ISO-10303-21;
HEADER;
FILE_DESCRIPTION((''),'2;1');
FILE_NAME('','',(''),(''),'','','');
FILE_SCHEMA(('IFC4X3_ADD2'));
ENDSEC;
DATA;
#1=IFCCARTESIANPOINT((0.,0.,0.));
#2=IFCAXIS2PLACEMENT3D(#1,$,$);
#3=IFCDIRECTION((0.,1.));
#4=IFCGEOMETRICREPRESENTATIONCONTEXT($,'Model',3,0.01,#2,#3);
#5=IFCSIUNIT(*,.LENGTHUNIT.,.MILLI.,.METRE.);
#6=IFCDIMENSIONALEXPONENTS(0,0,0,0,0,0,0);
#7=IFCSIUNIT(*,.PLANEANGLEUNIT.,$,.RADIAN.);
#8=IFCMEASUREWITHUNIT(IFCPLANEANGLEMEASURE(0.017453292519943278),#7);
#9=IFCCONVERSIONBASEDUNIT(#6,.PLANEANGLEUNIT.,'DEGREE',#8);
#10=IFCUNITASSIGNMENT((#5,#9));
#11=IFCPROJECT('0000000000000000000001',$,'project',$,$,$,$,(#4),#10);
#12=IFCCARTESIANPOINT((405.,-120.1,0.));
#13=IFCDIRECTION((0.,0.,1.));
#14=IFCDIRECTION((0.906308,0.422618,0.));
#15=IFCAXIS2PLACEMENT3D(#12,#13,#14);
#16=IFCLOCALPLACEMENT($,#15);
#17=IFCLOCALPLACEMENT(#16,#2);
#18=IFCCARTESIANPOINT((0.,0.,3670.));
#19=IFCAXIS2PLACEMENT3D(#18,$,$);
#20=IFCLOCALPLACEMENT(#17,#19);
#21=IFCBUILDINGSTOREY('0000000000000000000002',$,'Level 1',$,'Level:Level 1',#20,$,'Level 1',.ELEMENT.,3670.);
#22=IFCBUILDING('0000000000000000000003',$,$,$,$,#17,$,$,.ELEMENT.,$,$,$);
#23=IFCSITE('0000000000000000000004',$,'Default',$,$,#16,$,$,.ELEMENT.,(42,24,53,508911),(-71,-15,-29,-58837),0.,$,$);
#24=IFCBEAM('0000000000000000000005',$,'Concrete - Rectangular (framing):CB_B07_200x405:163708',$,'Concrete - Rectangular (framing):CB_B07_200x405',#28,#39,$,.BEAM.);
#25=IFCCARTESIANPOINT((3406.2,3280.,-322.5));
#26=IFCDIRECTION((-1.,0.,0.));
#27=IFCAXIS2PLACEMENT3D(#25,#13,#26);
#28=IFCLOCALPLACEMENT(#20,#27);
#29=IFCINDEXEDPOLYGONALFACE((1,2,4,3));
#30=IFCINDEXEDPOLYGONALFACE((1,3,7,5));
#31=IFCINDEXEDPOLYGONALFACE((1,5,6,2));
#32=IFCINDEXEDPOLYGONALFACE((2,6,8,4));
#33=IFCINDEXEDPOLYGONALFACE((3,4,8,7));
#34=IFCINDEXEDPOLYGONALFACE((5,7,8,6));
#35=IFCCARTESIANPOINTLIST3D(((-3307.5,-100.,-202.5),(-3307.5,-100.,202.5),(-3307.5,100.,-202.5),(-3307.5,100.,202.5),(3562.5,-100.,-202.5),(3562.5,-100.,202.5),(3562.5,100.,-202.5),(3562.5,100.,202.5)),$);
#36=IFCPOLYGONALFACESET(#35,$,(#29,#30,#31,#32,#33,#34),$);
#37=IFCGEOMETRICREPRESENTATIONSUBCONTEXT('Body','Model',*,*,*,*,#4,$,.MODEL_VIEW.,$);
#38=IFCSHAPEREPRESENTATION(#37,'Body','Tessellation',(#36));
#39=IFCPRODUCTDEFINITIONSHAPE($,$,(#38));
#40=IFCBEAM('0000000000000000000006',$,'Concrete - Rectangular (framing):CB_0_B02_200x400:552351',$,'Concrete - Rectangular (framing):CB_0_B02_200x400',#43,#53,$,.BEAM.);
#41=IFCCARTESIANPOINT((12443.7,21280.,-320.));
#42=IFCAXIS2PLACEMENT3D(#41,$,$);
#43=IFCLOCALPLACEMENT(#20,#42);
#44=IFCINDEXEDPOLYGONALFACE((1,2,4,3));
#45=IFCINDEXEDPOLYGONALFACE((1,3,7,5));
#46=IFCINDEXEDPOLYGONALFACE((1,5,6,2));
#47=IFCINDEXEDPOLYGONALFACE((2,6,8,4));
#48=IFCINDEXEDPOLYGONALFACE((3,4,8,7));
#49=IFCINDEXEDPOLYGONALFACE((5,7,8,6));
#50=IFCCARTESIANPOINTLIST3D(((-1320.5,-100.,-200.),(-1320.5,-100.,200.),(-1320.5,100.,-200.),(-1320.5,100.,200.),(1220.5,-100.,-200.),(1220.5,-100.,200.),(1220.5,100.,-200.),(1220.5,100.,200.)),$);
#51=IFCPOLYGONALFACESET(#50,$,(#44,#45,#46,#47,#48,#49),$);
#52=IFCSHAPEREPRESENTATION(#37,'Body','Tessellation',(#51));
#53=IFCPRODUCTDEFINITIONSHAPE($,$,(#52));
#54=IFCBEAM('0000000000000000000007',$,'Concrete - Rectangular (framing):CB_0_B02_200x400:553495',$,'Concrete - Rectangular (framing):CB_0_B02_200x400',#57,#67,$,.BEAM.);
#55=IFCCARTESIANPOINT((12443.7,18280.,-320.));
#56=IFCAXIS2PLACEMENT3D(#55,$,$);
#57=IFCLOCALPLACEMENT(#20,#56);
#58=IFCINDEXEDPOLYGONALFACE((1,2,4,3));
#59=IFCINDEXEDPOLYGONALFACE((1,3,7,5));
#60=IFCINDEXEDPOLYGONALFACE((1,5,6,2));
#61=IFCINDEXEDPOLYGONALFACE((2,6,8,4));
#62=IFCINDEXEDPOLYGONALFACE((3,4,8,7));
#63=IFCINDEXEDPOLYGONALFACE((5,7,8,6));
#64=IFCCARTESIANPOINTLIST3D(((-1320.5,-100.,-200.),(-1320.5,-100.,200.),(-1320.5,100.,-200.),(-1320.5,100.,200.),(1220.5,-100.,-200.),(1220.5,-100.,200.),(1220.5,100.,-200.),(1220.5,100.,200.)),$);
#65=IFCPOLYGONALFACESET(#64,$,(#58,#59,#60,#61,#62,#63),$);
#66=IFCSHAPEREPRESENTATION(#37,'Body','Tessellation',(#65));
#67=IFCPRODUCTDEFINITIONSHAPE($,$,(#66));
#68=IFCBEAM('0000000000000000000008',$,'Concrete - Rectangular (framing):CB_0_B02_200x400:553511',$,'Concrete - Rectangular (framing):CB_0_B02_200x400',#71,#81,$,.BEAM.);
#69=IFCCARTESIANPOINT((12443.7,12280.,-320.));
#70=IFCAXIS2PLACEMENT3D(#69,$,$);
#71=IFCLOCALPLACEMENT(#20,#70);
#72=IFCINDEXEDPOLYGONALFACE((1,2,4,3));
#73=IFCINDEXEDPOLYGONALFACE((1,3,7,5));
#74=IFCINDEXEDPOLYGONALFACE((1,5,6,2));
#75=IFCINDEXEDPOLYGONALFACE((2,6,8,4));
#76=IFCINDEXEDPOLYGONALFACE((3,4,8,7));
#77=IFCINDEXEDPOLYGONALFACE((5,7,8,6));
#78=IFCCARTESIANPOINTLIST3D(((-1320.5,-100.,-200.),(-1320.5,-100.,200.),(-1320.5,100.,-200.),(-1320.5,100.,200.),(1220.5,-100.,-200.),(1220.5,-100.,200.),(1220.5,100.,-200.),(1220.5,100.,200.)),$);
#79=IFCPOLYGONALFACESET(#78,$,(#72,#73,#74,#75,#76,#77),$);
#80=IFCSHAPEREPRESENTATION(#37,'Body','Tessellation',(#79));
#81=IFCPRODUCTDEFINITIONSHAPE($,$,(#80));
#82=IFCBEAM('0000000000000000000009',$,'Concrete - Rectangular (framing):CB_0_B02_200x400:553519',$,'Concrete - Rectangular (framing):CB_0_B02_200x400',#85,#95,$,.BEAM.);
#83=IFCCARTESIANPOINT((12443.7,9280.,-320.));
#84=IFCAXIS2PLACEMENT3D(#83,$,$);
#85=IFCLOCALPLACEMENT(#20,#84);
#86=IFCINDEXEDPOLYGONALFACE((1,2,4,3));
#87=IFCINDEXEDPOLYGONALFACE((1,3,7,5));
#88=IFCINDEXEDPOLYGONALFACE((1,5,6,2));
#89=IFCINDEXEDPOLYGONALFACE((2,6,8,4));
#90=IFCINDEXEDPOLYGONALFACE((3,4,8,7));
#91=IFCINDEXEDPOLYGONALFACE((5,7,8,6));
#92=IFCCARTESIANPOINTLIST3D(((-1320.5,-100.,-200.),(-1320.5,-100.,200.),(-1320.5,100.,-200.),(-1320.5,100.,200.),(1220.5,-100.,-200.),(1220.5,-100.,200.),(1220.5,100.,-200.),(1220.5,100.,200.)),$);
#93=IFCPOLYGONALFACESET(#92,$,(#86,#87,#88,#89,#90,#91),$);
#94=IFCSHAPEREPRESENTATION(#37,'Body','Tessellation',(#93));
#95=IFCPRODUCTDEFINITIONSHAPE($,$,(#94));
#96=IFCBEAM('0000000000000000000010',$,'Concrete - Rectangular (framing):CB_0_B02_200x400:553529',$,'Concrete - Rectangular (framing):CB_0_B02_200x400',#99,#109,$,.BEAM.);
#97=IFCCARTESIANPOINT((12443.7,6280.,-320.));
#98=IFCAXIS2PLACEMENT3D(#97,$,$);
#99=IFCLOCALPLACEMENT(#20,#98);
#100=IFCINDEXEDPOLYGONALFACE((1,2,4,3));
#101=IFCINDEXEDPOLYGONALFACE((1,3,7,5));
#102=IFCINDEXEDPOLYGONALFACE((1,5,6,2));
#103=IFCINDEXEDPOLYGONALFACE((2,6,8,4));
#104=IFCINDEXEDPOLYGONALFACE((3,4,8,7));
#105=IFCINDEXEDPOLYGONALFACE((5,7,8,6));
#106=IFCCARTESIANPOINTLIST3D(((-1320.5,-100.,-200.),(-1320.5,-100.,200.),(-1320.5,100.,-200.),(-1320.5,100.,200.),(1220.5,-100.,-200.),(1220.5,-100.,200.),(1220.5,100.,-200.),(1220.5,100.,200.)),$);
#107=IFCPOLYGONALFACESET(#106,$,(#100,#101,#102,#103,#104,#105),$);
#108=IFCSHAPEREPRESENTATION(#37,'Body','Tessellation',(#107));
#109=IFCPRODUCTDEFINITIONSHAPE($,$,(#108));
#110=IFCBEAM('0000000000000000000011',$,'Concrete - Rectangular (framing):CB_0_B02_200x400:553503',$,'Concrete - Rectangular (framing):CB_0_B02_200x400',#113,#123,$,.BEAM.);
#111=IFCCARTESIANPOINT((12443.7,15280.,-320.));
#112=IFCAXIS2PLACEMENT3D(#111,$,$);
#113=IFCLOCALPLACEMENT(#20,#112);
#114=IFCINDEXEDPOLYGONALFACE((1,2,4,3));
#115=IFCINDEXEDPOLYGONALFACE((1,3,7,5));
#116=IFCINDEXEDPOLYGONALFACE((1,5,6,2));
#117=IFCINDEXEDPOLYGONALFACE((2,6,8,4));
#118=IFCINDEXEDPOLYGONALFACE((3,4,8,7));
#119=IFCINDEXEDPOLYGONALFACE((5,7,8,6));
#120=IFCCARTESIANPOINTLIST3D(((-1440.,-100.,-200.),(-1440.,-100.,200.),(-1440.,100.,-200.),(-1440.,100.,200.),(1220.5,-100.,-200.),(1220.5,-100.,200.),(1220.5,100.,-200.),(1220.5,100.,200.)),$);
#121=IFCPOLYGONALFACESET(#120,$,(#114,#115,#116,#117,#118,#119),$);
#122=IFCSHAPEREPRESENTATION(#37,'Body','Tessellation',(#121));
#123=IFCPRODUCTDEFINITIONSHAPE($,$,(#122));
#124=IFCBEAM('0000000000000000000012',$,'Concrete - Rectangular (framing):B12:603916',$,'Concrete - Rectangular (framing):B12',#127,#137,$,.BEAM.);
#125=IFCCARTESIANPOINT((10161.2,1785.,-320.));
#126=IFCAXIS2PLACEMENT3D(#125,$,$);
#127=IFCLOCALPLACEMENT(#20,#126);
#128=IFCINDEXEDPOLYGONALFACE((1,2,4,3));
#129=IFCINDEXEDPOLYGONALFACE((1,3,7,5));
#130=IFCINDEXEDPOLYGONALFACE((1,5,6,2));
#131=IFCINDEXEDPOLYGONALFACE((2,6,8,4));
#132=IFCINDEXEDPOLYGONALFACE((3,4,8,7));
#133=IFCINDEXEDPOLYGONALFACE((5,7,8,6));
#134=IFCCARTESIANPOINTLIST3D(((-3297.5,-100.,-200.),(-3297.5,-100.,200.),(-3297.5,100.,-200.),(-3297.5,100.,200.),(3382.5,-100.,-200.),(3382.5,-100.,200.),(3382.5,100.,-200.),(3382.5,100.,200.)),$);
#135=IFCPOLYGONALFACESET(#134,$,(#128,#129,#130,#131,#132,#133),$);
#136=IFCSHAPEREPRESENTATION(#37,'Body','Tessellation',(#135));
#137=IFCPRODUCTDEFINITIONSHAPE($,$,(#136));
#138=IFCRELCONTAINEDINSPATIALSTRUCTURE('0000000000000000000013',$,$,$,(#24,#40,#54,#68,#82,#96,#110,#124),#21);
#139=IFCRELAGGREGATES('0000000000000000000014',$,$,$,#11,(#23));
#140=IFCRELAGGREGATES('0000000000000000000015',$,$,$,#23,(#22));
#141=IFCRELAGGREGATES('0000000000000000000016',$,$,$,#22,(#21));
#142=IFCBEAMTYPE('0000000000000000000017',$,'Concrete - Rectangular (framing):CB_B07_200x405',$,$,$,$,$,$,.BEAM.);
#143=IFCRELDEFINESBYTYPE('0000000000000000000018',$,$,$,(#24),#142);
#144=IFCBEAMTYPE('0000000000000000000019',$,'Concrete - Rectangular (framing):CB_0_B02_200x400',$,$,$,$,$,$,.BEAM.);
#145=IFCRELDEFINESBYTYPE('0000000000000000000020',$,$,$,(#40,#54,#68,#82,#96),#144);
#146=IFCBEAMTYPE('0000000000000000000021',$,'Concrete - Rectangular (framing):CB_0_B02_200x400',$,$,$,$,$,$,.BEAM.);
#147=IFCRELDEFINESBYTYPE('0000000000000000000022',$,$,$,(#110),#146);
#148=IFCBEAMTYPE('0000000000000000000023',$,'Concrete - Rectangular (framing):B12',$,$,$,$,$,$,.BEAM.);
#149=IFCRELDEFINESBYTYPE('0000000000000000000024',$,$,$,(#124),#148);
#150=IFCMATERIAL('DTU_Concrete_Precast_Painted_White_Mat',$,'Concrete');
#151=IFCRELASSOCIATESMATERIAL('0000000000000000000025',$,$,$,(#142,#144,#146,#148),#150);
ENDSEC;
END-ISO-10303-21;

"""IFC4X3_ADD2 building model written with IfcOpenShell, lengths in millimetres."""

from ifc_helpers import new_model, entity, si_unit, converted_unit, direction, frame, frame_2d, origin, origin_2d_with_axis, place, context, subcontext, project, spatial, rectangle, extrude, source, transform, mapped, material, material_profile, profile_set, type_object, type_shapes, element, save


model = new_model("IFC4X3_ADD2")

# Units and contexts
model_context = context("Model", 3, precision=0.01, world=origin(), true_north=direction((0.0, 1.0)))
body_context = subcontext(model_context, "Body", "Model", "MODEL_VIEW")
ifc_project = project(units=[si_unit("LENGTHUNIT", "METRE", prefix="MILLI"), converted_unit("PLANEANGLEUNIT", "DEGREE", entity("IfcPlaneAngleMeasure", 0.017453292519943278), si_unit("PLANEANGLEUNIT", "RADIAN"), dimensions=[0, 0, 0, 0, 0, 0, 0])], contexts=[model_context])

# Site, building, storey
site_placement = place(None, frame((405.0, -120.1, 0.0), z_axis=(0.0, 0.0, 1.0), x_axis=(0.906308, 0.422618, 0.0)))
site = spatial("IfcSite", under=ifc_project, at=site_placement, Name="Default", CompositionType="ELEMENT", RefLatitude=(42, 24, 53, 508911), RefLongitude=(-71, -15, -29, -58837), RefElevation=0.0)
building_placement = place(site_placement, origin())
building = spatial("IfcBuilding", under=site, at=building_placement, CompositionType="ELEMENT")
storey_placement = place(building_placement, frame((0.0, 0.0, 3670.0)))
storey = spatial("IfcBuildingStorey", under=building, at=storey_placement, Name="Level 1", ObjectType="Level:Level 1", LongName="Level 1", CompositionType="ELEMENT", Elevation=3670.0)

# Beams
ifc_material_1 = material(Name="DTU_Concrete_Precast_Painted_White_Mat", Category="Concrete")
ifc_material_profile_1 = material_profile(ifc_material_1, rectangle(XDim=7035.5, YDim=200.0, at=frame_2d((0.0, 0.0), x_axis=(1.0, 0.0))), Name="CB_0_B02_200x400")
ifc_profile_set_1 = profile_set([ifc_material_profile_1], Name="CB_0_B02_200x400")
ifc_material_profile_2 = material_profile(ifc_material_1, rectangle(XDim=6850.0, YDim=200.0, at=origin_2d_with_axis()), Name="CB_B07_200x405")
ifc_profile_set_2 = profile_set([ifc_material_profile_2], Name="CB_B07_200x405")
beam_type_1 = type_object("IfcBeamType", Name="Concrete - Rectangular (framing):CB_B07_200x405", PredefinedType="BEAM", material=ifc_profile_set_2)
shared_shape_1 = source(origin(), body_context, "Body", "SweptSolid", [
    extrude(rectangle(XDim=6870.0, YDim=200.0, at=origin_2d_with_axis()), frame((127.5, 0.0, -202.5), z_axis=(0.0, 0.0, 1.0), x_axis=(-1.0, 0.0, 0.0)), (0.0, 0.0, 1.0), 405.0),
])
type_shapes(beam_type_1, [shared_shape_1])
beam_1_placement = place(storey_placement, frame((3406.2, 3280.0, -322.5), z_axis=(0.0, 0.0, 1.0), x_axis=(-1.0, 0.0, 0.0)))
element("IfcBeam", 1, at=beam_1_placement, inside=storey, type_object=beam_type_1, Name="Concrete - Rectangular (framing):CB_B07_200x405:163708", ObjectType="Concrete - Rectangular (framing):CB_B07_200x405", PredefinedType="BEAM", context=body_context, shape_type="MappedRepresentation", body=[
    mapped(shared_shape_1, transform((0.0, 0.0, 0.0), scale=1.0)),
])
beam_type_2 = type_object("IfcBeamType", Name="Concrete - Rectangular (framing):CB_0_B02_200x400", PredefinedType="BEAM", material=ifc_profile_set_1)
shared_shape_2 = source(origin(), body_context, "Body", "SweptSolid", [
    extrude(rectangle(XDim=2541.0, YDim=200.0, at=origin_2d_with_axis()), frame((-50.0, 0.0, -200.0), z_axis=(0.0, 0.0, 1.0), x_axis=(-1.0, 0.0, 0.0)), (0.0, 0.0, 1.0), 400.0),
])
type_shapes(beam_type_2, [shared_shape_2])
for number, where, name in (
    (2, (12443.7, 21280.0, -320.0), "Concrete - Rectangular (framing):CB_0_B02_200x400:552351"),
    (3, (12443.7, 18280.0, -320.0), "Concrete - Rectangular (framing):CB_0_B02_200x400:553495"),
    (4, (12443.7, 12280.0, -320.0), "Concrete - Rectangular (framing):CB_0_B02_200x400:553511"),
    (5, (12443.7, 9280.0, -320.0), "Concrete - Rectangular (framing):CB_0_B02_200x400:553519"),
    (6, (12443.7, 6280.0, -320.0), "Concrete - Rectangular (framing):CB_0_B02_200x400:553529"),
):
    element("IfcBeam", number, at=place(storey_placement, frame(where)), inside=storey, type_object=beam_type_2, Name=name, ObjectType="Concrete - Rectangular (framing):CB_0_B02_200x400", PredefinedType="BEAM", context=body_context, shape_type="MappedRepresentation", body=[
        mapped(shared_shape_2, transform((0.0, 0.0, 0.0), scale=1.0)),
    ])
beam_type_3 = type_object("IfcBeamType", Name="Concrete - Rectangular (framing):CB_0_B02_200x400", PredefinedType="BEAM", material=ifc_profile_set_1)
shared_shape_3 = source(origin(), body_context, "Body", "SweptSolid", [
    extrude(rectangle(XDim=2660.5, YDim=200.0, at=origin_2d_with_axis()), frame((-109.8, 0.0, -200.0), z_axis=(0.0, 0.0, 1.0), x_axis=(-1.0, 0.0, 0.0)), (0.0, 0.0, 1.0), 400.0),
])
type_shapes(beam_type_3, [shared_shape_3])
beam_2_placement = place(storey_placement, frame((12443.7, 15280.0, -320.0)))
element("IfcBeam", 7, at=beam_2_placement, inside=storey, type_object=beam_type_3, Name="Concrete - Rectangular (framing):CB_0_B02_200x400:553503", ObjectType="Concrete - Rectangular (framing):CB_0_B02_200x400", PredefinedType="BEAM", context=body_context, shape_type="MappedRepresentation", body=[
    mapped(shared_shape_3, transform((0.0, 0.0, 0.0), scale=1.0)),
])
ifc_material_profile_3 = material_profile(ifc_material_1, rectangle(XDim=6700.0, YDim=200.0, at=origin_2d_with_axis()), Name="B12")
ifc_profile_set_3 = profile_set([ifc_material_profile_3], Name="B12")
beam_type_4 = type_object("IfcBeamType", Name="Concrete - Rectangular (framing):B12", PredefinedType="BEAM", material=ifc_profile_set_3)
shared_shape_4 = source(origin(), body_context, "Body", "SweptSolid", [
    extrude(rectangle(XDim=6680.0, YDim=200.0, at=origin_2d_with_axis()), frame((42.5, 0.0, -200.0), z_axis=(0.0, 0.0, 1.0), x_axis=(-1.0, 0.0, 0.0)), (0.0, 0.0, 1.0), 400.0),
])
type_shapes(beam_type_4, [shared_shape_4])
beam_3_placement = place(storey_placement, frame((10161.2, 1785.0, -320.0)))
element("IfcBeam", 8, at=beam_3_placement, inside=storey, type_object=beam_type_4, Name="Concrete - Rectangular (framing):B12:603916", ObjectType="Concrete - Rectangular (framing):B12", PredefinedType="BEAM", context=body_context, shape_type="MappedRepresentation", body=[
    mapped(shared_shape_4, transform((0.0, 0.0, 0.0), scale=1.0)),
])

save(model, "model.ifc")
